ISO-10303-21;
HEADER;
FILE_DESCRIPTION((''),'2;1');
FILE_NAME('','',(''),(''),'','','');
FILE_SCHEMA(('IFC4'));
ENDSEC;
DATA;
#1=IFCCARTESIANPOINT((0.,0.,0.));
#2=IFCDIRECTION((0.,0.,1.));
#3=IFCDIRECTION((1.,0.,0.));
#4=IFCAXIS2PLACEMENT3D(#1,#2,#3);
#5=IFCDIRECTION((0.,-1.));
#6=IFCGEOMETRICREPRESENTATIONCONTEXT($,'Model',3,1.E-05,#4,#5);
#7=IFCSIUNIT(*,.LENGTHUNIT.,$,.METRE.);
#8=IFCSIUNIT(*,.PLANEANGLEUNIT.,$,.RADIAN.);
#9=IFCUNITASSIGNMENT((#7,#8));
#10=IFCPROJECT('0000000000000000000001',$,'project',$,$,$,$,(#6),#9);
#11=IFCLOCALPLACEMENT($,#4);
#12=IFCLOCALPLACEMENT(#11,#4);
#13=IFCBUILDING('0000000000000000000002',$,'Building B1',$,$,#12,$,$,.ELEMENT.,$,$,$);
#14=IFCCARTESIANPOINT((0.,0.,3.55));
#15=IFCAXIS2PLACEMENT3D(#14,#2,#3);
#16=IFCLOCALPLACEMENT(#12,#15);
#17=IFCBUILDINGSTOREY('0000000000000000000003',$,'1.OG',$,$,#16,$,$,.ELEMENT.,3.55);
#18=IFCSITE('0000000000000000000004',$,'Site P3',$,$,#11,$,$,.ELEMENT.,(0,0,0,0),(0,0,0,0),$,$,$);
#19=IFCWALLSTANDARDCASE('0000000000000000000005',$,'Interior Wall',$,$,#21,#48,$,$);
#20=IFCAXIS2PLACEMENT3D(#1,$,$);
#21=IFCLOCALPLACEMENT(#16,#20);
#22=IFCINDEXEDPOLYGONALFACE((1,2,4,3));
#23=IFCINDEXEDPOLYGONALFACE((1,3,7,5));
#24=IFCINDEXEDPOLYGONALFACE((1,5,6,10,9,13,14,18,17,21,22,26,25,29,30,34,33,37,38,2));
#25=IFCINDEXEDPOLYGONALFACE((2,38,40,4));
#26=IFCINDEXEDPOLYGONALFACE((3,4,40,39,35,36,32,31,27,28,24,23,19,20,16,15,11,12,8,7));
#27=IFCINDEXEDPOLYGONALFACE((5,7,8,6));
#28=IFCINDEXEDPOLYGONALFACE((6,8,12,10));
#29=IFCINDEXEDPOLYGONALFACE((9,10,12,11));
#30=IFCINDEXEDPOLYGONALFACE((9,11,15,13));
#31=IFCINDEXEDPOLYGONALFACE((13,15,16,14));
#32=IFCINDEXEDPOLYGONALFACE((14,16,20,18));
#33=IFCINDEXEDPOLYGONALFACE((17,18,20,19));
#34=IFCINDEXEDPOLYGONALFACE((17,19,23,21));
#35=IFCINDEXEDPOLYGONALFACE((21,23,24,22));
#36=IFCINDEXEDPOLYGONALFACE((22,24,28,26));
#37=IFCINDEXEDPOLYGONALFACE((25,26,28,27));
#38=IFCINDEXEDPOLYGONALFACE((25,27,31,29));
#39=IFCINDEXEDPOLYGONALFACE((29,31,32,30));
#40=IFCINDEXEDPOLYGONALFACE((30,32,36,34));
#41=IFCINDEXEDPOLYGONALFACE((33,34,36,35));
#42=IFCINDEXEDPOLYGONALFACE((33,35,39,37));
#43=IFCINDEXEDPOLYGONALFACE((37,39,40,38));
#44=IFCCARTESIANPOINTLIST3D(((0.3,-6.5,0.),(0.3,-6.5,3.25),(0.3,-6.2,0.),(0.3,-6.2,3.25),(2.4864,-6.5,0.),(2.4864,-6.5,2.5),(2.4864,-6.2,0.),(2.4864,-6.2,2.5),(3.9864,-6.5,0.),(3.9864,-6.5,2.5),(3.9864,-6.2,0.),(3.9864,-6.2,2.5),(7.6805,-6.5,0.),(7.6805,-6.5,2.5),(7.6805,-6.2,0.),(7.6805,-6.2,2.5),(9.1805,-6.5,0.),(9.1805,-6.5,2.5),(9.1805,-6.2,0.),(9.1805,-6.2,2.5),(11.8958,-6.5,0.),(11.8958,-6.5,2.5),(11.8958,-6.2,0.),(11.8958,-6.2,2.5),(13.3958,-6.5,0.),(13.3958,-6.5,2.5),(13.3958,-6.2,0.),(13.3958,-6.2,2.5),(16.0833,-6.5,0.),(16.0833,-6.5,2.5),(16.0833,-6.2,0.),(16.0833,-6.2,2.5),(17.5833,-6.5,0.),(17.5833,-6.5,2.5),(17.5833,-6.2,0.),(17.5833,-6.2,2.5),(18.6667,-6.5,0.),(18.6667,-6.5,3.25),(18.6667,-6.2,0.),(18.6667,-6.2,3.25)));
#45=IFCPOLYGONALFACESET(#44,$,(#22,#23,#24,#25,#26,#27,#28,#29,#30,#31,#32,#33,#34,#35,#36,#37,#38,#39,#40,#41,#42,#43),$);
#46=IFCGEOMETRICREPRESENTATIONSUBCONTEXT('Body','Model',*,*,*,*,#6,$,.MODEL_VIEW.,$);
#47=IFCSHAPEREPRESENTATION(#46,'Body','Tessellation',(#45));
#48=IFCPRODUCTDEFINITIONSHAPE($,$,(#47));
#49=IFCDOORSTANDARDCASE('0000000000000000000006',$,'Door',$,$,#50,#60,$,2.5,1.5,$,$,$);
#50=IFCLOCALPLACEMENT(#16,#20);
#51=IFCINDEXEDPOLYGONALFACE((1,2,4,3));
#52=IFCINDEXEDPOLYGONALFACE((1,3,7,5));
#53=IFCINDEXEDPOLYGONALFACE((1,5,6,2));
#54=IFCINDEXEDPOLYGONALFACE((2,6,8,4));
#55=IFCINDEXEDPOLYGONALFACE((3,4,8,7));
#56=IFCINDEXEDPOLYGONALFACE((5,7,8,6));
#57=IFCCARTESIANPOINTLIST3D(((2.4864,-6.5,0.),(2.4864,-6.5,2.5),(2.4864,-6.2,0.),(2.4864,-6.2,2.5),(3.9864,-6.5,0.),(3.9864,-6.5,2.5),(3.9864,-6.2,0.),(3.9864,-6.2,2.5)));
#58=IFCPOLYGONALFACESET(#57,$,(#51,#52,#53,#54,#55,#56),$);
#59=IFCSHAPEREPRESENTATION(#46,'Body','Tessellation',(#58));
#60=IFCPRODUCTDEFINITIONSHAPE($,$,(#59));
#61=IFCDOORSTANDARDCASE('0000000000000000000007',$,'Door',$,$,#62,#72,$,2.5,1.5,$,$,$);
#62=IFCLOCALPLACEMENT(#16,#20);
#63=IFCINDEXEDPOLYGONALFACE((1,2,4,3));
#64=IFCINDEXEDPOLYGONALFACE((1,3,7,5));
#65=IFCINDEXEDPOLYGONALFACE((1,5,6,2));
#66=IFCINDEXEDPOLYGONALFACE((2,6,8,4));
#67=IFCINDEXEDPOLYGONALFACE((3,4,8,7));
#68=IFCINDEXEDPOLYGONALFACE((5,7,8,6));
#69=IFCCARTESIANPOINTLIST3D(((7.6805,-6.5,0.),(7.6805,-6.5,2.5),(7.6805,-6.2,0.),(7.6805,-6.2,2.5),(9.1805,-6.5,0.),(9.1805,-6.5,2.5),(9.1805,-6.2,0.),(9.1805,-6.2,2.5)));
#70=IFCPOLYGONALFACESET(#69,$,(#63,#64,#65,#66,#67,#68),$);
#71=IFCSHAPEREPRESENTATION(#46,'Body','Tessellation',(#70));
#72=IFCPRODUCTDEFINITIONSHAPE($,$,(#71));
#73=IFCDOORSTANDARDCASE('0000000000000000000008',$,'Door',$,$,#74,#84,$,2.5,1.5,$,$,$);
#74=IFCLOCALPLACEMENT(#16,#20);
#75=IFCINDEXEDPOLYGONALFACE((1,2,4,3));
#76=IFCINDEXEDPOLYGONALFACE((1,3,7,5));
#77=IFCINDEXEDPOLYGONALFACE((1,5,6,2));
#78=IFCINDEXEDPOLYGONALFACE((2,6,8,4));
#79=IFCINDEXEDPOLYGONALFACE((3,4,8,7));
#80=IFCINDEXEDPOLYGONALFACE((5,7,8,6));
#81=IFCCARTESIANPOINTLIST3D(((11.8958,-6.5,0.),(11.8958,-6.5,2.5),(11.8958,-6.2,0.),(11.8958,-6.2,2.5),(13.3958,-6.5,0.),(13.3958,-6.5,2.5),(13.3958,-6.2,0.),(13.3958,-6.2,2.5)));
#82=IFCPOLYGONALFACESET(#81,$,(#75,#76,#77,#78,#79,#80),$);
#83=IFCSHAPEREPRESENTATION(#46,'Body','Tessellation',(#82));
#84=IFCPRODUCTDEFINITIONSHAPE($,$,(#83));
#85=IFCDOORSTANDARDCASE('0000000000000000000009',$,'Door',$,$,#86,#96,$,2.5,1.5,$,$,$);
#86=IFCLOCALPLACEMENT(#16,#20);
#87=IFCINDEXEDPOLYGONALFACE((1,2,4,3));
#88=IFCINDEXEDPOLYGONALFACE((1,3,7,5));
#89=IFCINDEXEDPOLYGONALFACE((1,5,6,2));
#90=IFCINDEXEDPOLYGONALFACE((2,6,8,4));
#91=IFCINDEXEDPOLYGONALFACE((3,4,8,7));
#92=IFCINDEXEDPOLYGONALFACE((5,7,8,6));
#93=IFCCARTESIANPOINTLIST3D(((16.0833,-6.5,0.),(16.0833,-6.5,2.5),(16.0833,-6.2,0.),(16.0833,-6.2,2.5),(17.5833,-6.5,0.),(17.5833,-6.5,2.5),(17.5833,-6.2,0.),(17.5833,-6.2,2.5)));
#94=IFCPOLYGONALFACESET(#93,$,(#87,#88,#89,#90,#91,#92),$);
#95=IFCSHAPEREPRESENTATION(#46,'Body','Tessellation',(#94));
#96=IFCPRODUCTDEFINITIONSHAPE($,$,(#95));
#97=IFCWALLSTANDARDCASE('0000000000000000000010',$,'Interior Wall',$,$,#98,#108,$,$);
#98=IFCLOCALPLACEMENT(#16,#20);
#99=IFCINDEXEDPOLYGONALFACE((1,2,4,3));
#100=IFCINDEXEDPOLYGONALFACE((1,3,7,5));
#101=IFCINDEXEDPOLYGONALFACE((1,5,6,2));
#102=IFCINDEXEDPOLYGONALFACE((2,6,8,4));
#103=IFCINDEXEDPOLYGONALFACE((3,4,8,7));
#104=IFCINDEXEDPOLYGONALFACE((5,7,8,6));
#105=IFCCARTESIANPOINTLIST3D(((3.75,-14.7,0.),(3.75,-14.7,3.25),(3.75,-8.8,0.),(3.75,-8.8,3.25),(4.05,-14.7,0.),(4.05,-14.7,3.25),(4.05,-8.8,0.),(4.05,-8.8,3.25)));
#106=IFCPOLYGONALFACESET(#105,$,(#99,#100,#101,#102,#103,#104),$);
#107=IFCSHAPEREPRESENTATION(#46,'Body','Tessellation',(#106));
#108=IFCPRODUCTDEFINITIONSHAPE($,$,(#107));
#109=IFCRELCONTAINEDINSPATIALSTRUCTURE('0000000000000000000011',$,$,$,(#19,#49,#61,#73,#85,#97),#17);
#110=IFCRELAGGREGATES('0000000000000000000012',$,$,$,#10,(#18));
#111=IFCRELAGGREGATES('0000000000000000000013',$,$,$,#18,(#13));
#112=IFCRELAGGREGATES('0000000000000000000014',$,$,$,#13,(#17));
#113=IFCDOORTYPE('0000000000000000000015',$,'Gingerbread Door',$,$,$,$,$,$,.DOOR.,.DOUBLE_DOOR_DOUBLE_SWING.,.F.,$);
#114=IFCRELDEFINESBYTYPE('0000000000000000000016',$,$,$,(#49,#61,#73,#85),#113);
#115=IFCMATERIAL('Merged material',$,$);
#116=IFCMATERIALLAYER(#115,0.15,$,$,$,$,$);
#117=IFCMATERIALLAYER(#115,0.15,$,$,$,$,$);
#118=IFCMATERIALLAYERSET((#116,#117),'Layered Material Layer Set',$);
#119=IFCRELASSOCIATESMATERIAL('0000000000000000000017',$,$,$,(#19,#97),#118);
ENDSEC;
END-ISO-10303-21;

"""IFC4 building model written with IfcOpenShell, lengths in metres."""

from ifc_helpers import new_model, si_unit, direction, frame, origin_with_axes, place, context, subcontext, project, spatial, polyline, outline, extrude, source, transform, mapped, material, layer, layer_set, layer_usage, type_object, element, fill, save


model = new_model("IFC4")

# Units and contexts
model_context = context("Model", 3, precision=1e-05, world=origin_with_axes(), true_north=direction((0.0, -1.0)))
body_context = subcontext(model_context, "Body", "Model", "MODEL_VIEW")
ifc_project = project(units=[si_unit("LENGTHUNIT", "METRE"), si_unit("PLANEANGLEUNIT", "RADIAN")], contexts=[model_context])

# Site, building, storey
site_placement = place(None, origin_with_axes())
site = spatial("IfcSite", under=ifc_project, at=site_placement, Name="Site P3", CompositionType="ELEMENT", RefLatitude=(0, 0, 0, 0), RefLongitude=(0, 0, 0, 0))
building_placement = place(site_placement, origin_with_axes())
building = spatial("IfcBuilding", under=site, at=building_placement, Name="Building B1", CompositionType="ELEMENT")
storey_placement = place(building_placement, frame((0.0, 0.0, 3.55), z_axis=(0.0, 0.0, 1.0), x_axis=(1.0, 0.0, 0.0)))
storey = spatial("IfcBuildingStorey", under=building, at=storey_placement, Name="1.OG", CompositionType="ELEMENT", Elevation=3.55)

# Shared definitions
ifc_material = material(Name="Merged material")

# Wall, openings, doors
ifc_layer_1 = layer(ifc_material, 0.15)
ifc_layer_2 = layer(ifc_material, 0.15)
ifc_layer_set_1 = layer_set([ifc_layer_1, ifc_layer_2], Name="Layered Material Layer Set")
ifc_layer_usage_1 = layer_usage(ifc_layer_set_1, "AXIS2", "POSITIVE", -0.15)
door_type = type_object("IfcDoorType", Name="Gingerbread Door", OperationType="DOUBLE_DOOR_DOUBLE_SWING", ParameterTakesPrecedence=False, PredefinedType="DOOR")
shared_shape_1 = source(origin_with_axes(), body_context, "Body", "SweptSolid", [
    extrude(outline(polyline([(0.0, 0.0), (0.0, 1.5), (2.5, 1.5), (2.5, 0.0), (0.0, 0.0)])), frame((0.0, -0.15, 0.0), z_axis=(0.0, 1.0, 0.0), x_axis=(0.0, 0.0, 1.0)), (0.0, 0.0, 1.0), 0.3),
])
wall_1_placement = place(storey_placement, frame((0.3, -6.35, 0.0), z_axis=(0.0, 0.0, 1.0), x_axis=(1.0, 0.0, 0.0)))
wall_1 = element("IfcWallStandardCase", 1, at=wall_1_placement, inside=storey, material=ifc_layer_usage_1, Name="Interior Wall", context=body_context, shape_type="SweptSolid", body=[
    extrude(outline(polyline([(0.0, 0.15), (18.3667, 0.15), (18.3667, -0.15), (0.0, -0.15), (0.0, 0.15)])), origin_with_axes(), (0.0, 0.0, 1.0), 3.25),
])
opening_1_placement = place(wall_1_placement, frame((2.1864, 0.0, 0.0), z_axis=(0.0, 0.0, 1.0), x_axis=(1.0, 0.0, 0.0)))
opening_1 = element("IfcOpeningStandardCase", 2, at=opening_1_placement, cuts=wall_1, context=body_context, shape_type="SweptSolid", body=[
    extrude(outline(polyline([(0.0, 0.0), (0.0, 1.5), (2.5, 1.5), (2.5, 0.0), (0.0, 0.0)])), frame((0.0, -0.15, 0.0), z_axis=(0.0, 1.0, 0.0), x_axis=(0.0, 0.0, 1.0)), (0.0, 0.0, 1.0), 0.3),
])
opening_2_placement = place(wall_1_placement, frame((7.3805, 0.0, 0.0), z_axis=(0.0, 0.0, 1.0), x_axis=(1.0, 0.0, 0.0)))
opening_2 = element("IfcOpeningStandardCase", 3, at=opening_2_placement, cuts=wall_1, context=body_context, shape_type="SweptSolid", body=[
    extrude(outline(polyline([(0.0, 0.0), (0.0, 1.5), (2.5, 1.5), (2.5, 0.0), (0.0, 0.0)])), frame((0.0, -0.15, 0.0), z_axis=(0.0, 1.0, 0.0), x_axis=(0.0, 0.0, 1.0)), (0.0, 0.0, 1.0), 0.3),
])
opening_3_placement = place(wall_1_placement, frame((11.5958, 0.0, 0.0), z_axis=(0.0, 0.0, 1.0), x_axis=(1.0, 0.0, 0.0)))
opening_3 = element("IfcOpeningStandardCase", 4, at=opening_3_placement, cuts=wall_1, context=body_context, shape_type="SweptSolid", body=[
    extrude(outline(polyline([(0.0, 0.0), (0.0, 1.5), (2.5, 1.5), (2.5, 0.0), (0.0, 0.0)])), frame((0.0, -0.15, 0.0), z_axis=(0.0, 1.0, 0.0), x_axis=(0.0, 0.0, 1.0)), (0.0, 0.0, 1.0), 0.3),
])
opening_4_placement = place(wall_1_placement, frame((15.7833, 0.0, 0.0), z_axis=(0.0, 0.0, 1.0), x_axis=(1.0, 0.0, 0.0)))
opening_4 = element("IfcOpeningStandardCase", 5, at=opening_4_placement, cuts=wall_1, context=body_context, shape_type="SweptSolid", body=[
    extrude(outline(polyline([(0.0, 0.0), (0.0, 1.5), (2.5, 1.5), (2.5, 0.0), (0.0, 0.0)])), frame((0.0, -0.15, 0.0), z_axis=(0.0, 1.0, 0.0), x_axis=(0.0, 0.0, 1.0)), (0.0, 0.0, 1.0), 0.3),
])
door_1_placement = place(opening_1_placement, origin_with_axes())
door_1 = element("IfcDoorStandardCase", 6, at=door_1_placement, inside=storey, type_object=door_type, Name="Door", OverallHeight=2.5, OverallWidth=1.5, context=body_context, shape_type="MappedRepresentation", body=[
    mapped(shared_shape_1, transform((0.0, 0.0, 0.0))),
])
fill(opening_1, door_1)
door_2_placement = place(opening_2_placement, origin_with_axes())
door_2 = element("IfcDoorStandardCase", 7, at=door_2_placement, inside=storey, type_object=door_type, Name="Door", OverallHeight=2.5, OverallWidth=1.5, context=body_context, shape_type="MappedRepresentation", body=[
    mapped(shared_shape_1, transform((0.0, 0.0, 0.0))),
])
fill(opening_2, door_2)
door_3_placement = place(opening_3_placement, origin_with_axes())
door_3 = element("IfcDoorStandardCase", 8, at=door_3_placement, inside=storey, type_object=door_type, Name="Door", OverallHeight=2.5, OverallWidth=1.5, context=body_context, shape_type="MappedRepresentation", body=[
    mapped(shared_shape_1, transform((0.0, 0.0, 0.0))),
])
fill(opening_3, door_3)
door_4_placement = place(opening_4_placement, origin_with_axes())
door_4 = element("IfcDoorStandardCase", 9, at=door_4_placement, inside=storey, type_object=door_type, Name="Door", OverallHeight=2.5, OverallWidth=1.5, context=body_context, shape_type="MappedRepresentation", body=[
    mapped(shared_shape_1, transform((0.0, 0.0, 0.0))),
])
fill(opening_4, door_4)

# Wall
wall_2_placement = place(storey_placement, frame((3.9, -8.8, 0.0), z_axis=(0.0, 0.0, 1.0), x_axis=(0.0, -1.0, 0.0)))
element("IfcWallStandardCase", 10, at=wall_2_placement, inside=storey, material=ifc_layer_usage_1, Name="Interior Wall", context=body_context, shape_type="SweptSolid", body=[
    extrude(outline(polyline([(0.0, 0.15), (5.9, 0.15), (5.9, -0.15), (0.0, -0.15), (0.0, 0.15)])), origin_with_axes(), (0.0, 0.0, 1.0), 3.25),
])

save(model, "model.ifc")
